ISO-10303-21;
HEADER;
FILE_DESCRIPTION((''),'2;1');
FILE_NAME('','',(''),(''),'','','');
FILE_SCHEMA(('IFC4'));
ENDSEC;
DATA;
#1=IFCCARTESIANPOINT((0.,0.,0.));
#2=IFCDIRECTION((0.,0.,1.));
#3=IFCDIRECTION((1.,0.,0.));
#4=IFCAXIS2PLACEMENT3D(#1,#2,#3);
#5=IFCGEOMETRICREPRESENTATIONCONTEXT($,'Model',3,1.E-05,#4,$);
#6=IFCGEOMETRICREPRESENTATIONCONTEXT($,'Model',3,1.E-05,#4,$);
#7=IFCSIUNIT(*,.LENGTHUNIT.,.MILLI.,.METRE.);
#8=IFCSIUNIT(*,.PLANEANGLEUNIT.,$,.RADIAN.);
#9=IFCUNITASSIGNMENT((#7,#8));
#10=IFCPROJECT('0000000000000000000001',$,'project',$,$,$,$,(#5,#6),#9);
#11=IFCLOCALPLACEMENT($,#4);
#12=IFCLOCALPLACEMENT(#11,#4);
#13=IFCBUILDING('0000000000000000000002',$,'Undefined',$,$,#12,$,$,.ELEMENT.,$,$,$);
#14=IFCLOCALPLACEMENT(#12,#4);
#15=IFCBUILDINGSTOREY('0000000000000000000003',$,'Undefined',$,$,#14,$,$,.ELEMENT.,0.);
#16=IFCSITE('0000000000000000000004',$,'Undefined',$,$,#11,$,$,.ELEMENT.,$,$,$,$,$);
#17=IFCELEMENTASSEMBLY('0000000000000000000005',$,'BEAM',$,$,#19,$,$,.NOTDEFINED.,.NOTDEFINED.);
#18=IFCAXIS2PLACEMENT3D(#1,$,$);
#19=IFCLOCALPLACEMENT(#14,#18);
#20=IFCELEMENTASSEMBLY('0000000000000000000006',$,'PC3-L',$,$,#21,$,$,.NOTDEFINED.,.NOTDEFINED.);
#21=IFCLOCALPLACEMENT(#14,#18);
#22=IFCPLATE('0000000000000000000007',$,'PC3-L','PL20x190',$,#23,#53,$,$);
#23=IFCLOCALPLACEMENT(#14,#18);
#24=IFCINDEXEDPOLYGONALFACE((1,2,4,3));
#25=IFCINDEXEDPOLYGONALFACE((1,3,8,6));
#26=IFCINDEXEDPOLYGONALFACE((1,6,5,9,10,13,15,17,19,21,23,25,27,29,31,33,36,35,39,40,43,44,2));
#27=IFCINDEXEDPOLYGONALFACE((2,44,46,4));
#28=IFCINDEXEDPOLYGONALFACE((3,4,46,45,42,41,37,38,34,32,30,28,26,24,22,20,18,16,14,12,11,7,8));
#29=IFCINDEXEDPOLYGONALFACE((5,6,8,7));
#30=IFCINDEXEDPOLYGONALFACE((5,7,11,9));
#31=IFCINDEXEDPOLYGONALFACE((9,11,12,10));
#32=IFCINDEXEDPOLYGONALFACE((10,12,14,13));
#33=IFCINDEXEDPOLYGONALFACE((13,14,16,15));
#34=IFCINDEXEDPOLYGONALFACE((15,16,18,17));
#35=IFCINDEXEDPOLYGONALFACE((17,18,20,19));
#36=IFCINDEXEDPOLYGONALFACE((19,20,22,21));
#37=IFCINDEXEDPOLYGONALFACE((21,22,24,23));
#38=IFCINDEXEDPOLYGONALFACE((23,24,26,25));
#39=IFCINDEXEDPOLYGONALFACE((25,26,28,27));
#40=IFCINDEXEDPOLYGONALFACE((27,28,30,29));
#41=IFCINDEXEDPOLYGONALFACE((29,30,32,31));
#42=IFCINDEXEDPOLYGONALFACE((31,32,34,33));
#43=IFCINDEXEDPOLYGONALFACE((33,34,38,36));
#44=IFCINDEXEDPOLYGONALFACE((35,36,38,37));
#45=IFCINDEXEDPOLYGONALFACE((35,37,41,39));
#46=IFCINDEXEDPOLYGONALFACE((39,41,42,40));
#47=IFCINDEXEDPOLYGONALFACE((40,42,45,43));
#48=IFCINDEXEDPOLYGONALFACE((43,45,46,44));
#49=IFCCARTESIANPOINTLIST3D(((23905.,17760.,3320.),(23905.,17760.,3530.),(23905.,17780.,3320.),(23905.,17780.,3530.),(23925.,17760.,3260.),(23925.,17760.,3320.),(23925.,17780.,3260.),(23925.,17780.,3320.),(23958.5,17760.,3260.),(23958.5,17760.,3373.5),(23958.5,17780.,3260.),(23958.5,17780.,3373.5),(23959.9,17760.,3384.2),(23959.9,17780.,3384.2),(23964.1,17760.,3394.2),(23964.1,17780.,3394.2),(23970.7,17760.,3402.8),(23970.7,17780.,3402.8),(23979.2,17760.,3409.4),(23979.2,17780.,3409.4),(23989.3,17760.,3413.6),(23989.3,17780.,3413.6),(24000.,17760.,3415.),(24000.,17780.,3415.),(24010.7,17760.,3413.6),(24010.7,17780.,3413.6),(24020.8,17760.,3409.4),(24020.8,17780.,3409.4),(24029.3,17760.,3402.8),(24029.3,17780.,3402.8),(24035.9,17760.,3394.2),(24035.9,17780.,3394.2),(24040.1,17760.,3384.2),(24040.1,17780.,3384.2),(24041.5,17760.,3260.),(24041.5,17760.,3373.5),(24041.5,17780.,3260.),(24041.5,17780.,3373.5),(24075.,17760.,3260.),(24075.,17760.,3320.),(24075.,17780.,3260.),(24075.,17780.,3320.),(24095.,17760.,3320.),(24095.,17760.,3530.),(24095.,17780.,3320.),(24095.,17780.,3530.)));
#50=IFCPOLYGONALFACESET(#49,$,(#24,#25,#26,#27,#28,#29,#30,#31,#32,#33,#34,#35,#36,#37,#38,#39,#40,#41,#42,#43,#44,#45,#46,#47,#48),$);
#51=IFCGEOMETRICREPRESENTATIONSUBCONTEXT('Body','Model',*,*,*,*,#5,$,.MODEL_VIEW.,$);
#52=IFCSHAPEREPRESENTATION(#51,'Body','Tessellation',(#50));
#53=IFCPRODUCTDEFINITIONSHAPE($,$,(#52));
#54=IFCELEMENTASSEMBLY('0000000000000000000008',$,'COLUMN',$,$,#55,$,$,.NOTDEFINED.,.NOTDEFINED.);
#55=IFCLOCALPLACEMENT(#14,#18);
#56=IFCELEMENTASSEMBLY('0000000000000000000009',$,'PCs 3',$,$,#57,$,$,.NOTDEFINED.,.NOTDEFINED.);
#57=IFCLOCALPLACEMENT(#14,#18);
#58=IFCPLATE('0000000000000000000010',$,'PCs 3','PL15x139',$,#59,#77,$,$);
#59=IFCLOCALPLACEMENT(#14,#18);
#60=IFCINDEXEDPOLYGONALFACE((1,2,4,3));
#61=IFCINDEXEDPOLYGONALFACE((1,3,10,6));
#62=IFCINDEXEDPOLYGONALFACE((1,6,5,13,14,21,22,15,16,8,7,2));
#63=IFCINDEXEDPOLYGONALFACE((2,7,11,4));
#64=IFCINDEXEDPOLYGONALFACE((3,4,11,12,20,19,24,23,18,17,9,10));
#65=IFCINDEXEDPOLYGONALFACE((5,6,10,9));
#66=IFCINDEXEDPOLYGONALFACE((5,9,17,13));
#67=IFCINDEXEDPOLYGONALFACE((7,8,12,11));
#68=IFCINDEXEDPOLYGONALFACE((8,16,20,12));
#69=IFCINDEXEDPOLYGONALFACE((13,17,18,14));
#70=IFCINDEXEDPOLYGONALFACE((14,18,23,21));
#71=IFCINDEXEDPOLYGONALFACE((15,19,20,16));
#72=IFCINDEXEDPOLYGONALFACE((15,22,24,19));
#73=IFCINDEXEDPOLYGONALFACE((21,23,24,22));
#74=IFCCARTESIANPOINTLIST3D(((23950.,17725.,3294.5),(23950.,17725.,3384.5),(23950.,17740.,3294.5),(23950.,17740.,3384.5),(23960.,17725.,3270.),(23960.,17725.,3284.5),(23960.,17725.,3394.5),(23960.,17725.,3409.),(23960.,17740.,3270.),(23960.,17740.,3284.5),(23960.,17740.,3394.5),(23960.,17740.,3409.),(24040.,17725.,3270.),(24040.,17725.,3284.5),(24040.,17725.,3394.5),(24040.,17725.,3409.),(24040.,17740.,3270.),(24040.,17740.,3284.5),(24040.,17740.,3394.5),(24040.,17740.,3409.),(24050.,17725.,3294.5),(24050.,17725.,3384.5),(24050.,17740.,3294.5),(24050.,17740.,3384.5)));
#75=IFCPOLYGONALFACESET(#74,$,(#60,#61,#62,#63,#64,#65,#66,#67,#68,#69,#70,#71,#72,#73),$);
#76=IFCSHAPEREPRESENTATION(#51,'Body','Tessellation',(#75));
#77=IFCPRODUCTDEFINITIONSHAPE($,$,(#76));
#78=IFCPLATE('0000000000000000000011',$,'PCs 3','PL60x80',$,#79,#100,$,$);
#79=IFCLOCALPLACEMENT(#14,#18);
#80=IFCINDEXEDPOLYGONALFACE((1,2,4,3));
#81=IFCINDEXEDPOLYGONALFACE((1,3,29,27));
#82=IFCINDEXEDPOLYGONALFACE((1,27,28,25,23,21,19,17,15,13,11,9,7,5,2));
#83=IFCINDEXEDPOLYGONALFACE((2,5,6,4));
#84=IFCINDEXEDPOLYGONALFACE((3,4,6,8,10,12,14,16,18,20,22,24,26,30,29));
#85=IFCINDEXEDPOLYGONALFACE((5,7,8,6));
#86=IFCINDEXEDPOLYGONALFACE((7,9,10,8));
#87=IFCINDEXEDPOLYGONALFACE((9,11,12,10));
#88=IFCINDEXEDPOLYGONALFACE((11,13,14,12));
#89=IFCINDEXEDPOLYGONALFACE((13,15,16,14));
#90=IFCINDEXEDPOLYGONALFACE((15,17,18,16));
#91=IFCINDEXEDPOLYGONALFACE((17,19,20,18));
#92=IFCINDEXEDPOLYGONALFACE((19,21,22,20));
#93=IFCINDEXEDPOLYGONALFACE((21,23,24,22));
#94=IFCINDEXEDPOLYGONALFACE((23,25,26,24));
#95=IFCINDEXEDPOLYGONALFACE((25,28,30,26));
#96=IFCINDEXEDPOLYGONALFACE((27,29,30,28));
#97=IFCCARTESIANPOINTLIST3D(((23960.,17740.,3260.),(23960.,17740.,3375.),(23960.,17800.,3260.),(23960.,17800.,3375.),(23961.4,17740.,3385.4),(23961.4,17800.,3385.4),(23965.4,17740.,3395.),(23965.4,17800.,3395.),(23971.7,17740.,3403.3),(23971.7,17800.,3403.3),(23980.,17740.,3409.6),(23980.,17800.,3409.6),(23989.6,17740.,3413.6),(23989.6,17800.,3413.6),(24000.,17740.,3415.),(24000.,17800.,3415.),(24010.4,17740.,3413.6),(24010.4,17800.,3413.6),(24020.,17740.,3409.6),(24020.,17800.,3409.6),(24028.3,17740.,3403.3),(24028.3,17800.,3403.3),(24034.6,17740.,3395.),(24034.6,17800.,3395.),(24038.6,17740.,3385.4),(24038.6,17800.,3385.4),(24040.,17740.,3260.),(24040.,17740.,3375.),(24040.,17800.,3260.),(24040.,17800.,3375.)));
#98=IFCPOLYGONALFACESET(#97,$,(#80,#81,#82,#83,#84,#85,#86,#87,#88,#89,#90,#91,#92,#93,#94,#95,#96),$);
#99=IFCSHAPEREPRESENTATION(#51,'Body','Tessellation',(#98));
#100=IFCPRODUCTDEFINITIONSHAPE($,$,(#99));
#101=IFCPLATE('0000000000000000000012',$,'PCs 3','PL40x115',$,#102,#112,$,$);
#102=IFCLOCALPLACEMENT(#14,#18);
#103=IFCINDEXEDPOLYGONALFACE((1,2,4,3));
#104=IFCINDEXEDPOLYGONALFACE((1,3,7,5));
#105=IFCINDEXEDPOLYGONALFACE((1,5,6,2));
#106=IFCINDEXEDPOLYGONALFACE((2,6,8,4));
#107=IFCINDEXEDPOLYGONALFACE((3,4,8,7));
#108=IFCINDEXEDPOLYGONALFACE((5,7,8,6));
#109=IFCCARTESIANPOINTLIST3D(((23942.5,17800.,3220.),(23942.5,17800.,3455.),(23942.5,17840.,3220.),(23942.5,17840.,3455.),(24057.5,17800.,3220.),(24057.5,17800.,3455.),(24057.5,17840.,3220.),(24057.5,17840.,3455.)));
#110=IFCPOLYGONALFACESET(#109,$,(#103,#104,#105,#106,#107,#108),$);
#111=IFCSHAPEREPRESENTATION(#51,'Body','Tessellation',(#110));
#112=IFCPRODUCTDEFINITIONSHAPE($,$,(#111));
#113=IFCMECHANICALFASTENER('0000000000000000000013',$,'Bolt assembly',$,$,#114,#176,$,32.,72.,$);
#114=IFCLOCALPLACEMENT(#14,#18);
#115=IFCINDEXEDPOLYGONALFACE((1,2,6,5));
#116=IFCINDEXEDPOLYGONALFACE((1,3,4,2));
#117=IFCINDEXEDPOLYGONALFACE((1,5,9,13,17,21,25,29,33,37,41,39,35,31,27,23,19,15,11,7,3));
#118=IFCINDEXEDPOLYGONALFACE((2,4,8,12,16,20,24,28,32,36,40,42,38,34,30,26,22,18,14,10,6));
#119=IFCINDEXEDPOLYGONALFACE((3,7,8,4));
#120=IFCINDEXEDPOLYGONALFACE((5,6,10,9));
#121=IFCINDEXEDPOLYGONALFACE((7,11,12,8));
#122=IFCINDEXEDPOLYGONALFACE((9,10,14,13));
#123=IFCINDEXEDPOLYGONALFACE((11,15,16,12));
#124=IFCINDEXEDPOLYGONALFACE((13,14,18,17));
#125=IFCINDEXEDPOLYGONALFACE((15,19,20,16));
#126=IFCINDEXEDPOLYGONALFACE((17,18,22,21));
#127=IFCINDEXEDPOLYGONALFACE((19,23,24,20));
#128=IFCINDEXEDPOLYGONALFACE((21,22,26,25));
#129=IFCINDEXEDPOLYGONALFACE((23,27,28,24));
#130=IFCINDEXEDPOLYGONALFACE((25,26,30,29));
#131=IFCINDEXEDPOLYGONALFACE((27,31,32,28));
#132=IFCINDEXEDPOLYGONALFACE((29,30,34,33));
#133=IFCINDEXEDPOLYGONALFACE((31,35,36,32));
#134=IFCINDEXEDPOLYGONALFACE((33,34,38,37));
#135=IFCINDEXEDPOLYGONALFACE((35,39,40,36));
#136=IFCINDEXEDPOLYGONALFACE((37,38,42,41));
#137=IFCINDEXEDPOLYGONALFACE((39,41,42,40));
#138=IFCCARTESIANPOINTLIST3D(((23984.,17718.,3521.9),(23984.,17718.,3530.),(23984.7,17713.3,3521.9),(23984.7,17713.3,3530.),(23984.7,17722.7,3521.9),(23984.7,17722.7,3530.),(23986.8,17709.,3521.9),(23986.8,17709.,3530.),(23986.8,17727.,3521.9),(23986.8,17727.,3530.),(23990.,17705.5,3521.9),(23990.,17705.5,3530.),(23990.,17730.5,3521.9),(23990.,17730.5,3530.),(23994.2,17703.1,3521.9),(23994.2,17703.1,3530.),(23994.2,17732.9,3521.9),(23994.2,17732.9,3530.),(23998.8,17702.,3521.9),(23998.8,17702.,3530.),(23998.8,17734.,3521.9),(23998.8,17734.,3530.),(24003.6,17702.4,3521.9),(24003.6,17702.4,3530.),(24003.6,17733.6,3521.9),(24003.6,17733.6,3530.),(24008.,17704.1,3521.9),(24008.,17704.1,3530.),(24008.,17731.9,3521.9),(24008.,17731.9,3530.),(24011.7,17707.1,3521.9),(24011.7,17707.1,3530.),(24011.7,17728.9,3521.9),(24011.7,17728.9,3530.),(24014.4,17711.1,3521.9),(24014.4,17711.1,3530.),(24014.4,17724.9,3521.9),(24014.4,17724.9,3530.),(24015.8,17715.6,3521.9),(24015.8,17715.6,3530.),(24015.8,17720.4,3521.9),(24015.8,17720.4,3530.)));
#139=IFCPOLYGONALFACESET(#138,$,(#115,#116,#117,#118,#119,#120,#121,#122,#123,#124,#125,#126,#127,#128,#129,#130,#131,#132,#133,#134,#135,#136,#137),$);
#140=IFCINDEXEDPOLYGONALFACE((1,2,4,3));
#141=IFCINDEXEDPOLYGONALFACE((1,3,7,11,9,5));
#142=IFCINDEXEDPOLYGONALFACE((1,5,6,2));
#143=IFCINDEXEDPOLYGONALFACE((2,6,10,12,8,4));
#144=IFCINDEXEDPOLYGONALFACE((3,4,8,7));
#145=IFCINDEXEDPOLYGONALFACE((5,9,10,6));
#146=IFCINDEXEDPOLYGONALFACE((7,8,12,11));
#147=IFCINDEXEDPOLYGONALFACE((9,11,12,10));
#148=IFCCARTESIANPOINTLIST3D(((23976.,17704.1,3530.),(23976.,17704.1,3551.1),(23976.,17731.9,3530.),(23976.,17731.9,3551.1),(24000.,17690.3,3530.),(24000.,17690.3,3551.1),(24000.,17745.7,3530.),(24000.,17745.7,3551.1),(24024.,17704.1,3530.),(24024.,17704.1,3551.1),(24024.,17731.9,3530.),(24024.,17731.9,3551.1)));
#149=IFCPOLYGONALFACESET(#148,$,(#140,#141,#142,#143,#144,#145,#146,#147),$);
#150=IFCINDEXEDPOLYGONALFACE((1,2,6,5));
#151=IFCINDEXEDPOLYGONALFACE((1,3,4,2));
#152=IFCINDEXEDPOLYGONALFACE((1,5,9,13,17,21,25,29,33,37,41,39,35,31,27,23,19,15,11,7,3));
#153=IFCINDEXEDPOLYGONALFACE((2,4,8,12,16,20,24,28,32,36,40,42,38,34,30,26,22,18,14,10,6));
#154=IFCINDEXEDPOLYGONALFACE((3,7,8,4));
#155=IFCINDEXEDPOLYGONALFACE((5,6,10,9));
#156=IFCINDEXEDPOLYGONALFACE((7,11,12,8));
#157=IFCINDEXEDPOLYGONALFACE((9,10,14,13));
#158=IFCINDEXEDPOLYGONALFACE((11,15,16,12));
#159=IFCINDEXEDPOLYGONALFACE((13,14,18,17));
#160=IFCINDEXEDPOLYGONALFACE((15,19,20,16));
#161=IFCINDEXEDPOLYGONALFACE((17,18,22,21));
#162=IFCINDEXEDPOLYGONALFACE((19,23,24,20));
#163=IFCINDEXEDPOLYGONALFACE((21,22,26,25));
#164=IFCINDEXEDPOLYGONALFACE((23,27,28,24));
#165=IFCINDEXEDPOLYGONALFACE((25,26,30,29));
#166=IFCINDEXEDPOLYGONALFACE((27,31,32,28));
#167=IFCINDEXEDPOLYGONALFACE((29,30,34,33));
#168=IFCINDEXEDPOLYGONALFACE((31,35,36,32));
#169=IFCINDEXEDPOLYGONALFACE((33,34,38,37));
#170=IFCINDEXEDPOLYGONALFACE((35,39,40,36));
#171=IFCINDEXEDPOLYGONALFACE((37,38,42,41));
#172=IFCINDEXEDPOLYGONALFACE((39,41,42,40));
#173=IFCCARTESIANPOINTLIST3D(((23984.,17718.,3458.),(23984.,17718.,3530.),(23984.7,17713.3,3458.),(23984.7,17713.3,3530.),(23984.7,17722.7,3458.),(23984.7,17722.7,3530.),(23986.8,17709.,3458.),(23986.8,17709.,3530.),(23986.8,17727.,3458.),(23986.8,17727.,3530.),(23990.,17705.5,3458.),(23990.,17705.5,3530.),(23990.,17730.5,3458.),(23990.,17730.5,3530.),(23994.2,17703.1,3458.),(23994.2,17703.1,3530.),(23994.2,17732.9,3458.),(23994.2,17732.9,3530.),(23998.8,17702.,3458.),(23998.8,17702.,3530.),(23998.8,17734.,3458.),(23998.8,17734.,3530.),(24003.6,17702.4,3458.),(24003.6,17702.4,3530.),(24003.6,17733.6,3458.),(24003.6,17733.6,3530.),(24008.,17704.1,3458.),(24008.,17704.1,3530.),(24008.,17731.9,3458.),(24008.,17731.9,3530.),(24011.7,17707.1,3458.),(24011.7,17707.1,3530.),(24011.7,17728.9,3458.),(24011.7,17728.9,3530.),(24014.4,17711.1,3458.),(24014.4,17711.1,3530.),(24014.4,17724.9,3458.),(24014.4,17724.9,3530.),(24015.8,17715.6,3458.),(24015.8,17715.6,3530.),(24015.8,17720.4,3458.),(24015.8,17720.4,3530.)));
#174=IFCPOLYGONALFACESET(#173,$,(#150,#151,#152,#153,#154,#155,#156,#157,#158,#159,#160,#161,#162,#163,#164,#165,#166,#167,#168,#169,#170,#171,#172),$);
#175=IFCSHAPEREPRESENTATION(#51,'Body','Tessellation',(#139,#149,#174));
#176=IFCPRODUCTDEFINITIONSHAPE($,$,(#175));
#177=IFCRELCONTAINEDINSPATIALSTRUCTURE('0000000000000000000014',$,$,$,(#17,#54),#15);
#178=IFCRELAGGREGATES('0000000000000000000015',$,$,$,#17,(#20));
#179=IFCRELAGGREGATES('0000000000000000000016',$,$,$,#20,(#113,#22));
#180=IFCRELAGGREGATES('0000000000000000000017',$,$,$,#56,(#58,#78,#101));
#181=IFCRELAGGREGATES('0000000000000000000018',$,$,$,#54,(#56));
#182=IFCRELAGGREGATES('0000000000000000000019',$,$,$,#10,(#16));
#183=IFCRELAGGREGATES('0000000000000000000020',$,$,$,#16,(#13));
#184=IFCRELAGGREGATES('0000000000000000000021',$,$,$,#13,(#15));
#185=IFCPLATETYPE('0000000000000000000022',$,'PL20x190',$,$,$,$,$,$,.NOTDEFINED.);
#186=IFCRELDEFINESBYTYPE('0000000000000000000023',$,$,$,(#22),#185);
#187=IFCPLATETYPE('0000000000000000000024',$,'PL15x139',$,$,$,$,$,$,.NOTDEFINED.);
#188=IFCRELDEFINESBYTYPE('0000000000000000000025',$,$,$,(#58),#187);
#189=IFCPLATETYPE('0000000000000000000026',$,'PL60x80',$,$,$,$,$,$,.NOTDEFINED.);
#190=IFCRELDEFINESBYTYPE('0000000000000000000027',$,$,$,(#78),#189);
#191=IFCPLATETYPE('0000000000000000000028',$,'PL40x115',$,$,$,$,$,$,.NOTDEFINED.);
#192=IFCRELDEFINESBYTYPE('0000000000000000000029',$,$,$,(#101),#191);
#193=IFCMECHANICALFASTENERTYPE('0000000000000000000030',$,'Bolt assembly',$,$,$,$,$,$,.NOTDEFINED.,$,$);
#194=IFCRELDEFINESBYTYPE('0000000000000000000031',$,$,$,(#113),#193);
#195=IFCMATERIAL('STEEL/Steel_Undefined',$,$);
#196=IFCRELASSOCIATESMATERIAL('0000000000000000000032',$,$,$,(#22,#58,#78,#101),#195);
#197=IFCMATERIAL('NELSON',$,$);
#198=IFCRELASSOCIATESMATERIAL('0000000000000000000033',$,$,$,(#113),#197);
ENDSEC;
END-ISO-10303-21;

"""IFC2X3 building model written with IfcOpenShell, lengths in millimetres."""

from ifc_helpers import new_model, si_unit, frame, frame_2d, origin_with_axes, origin_2d_with_axis, place, context, subcontext, project, spatial, polyline, circle_curve, parameter, trimmed, segment, composite_curve, circle, outline, extrude, source, transform, mapped, material, type_object, element, aggregate, save


model = new_model("IFC2X3")

# Units and contexts
model_context_1 = context("Model", 3, precision=1e-05, world=origin_with_axes())
model_context_2 = context("Model", 3, precision=1e-05, world=origin_with_axes())
body_context = subcontext(model_context_1, "Body", "Model", "MODEL_VIEW")
ifc_project = project(units=[si_unit("LENGTHUNIT", "METRE", prefix="MILLI"), si_unit("PLANEANGLEUNIT", "RADIAN")], contexts=[model_context_1, model_context_2])

# Site, building, storey
site_placement = place(None, origin_with_axes())
site = spatial("IfcSite", under=ifc_project, at=site_placement, Name="Undefined", CompositionType="ELEMENT")
building_placement = place(site_placement, origin_with_axes())
building = spatial("IfcBuilding", under=site, at=building_placement, Name="Undefined", CompositionType="ELEMENT")
storey_placement = place(building_placement, origin_with_axes())
storey = spatial("IfcBuildingStorey", under=building, at=storey_placement, Name="Undefined", CompositionType="ELEMENT", Elevation=0.0)

# Element assemblies
assembly_1_placement = place(storey_placement, origin_with_axes())
assembly_1 = element("IfcElementAssembly", 1, at=assembly_1_placement, inside=storey, Name="BEAM", AssemblyPlace="NOTDEFINED", PredefinedType="NOTDEFINED")
assembly_2_placement = place(assembly_1_placement, origin_with_axes())
assembly_2 = element("IfcElementAssembly", 2, at=assembly_2_placement, Name="PC3-L", AssemblyPlace="NOTDEFINED", PredefinedType="NOTDEFINED")
aggregate(assembly_1, [assembly_2])
ifc_material_1 = material(Name="STEEL/Steel_Undefined")

# Plate
plate_type_1 = type_object("IfcPlateType", Name="PL20x190", PredefinedType="NOTDEFINED")
plate_1_placement = place(assembly_2_placement, frame((24095.0, 17770.0, 3260.0), z_axis=(0.0, 1.0, 0.0), x_axis=(-1.0, 0.0, 0.0)))
plate_1 = element("IfcPlate", 3, at=plate_1_placement, type_object=plate_type_1, material=ifc_material_1, Name="PC3-L", Description="PL20x190", context=body_context, shape_type="SweptSolid", body=[
    extrude(outline(composite_curve([segment(polyline([(0.0, 60.0), (20.0, 60.0), (20.0, 0.0), (53.5, 0.0), (53.5, 113.5)]), True, "CONTINUOUS"), segment(trimmed(circle_curve(frame_2d((95.0, 113.5), x_axis=(-1.0, 0.0)), 41.5), [parameter(0.0)], [parameter(4.712389)], False, "PARAMETER"), True, "CONTINUOUS"), segment(polyline([(95.0, 155.0), (95.0, 155.0)]), True, "CONTINUOUS"), segment(trimmed(circle_curve(frame_2d((95.0, 113.5), x_axis=(0.0, 1.0)), 41.5), [parameter(0.0)], [parameter(4.712389)], False, "PARAMETER"), True, "CONTINUOUS"), segment(polyline([(136.5, 113.5), (136.5, 0.0), (170.0, 0.0), (170.0, 60.0), (190.0, 60.0), (190.0, 270.0), (0.0, 270.0), (0.0, 60.0)]), True, "CONTINUOUS")], self_intersect=True)), frame((0.0, 0.0, -10.0), z_axis=(0.0, 0.0, 1.0), x_axis=(1.0, 0.0, 0.0)), (0.0, 0.0, 1.0), 20.0),
])

# Element assemblies, plates
assembly_3_placement = place(storey_placement, origin_with_axes())
assembly_3 = element("IfcElementAssembly", 4, at=assembly_3_placement, inside=storey, Name="COLUMN", AssemblyPlace="NOTDEFINED", PredefinedType="NOTDEFINED")
assembly_4_placement = place(assembly_3_placement, origin_with_axes())
assembly_4 = element("IfcElementAssembly", 5, at=assembly_4_placement, Name="PCs 3", AssemblyPlace="NOTDEFINED", PredefinedType="NOTDEFINED")
plate_type_2 = type_object("IfcPlateType", Name="PL15x139", PredefinedType="NOTDEFINED")
plate_2_placement = place(assembly_4_placement, frame((23960.0, 17732.5, 3409.0), z_axis=(0.0, -1.0, 0.0), x_axis=(0.0, 0.0, -1.0)))
plate_2 = element("IfcPlate", 6, at=plate_2_placement, type_object=plate_type_2, material=ifc_material_1, Name="PCs 3", Description="PL15x139", context=body_context, shape_type="SweptSolid", body=[
    extrude(outline(polyline([(0.0, 0.0), (14.5, 0.0), (24.5, -10.0), (114.5, -10.0), (124.5, 0.0), (139.0, 0.0), (139.0, 80.0), (124.5, 80.0), (114.5, 90.0), (24.5, 90.0), (14.5, 80.0), (0.0, 80.0), (0.0, 0.0)])), frame((0.0, 0.0, -7.5), z_axis=(0.0, 0.0, 1.0), x_axis=(1.0, 0.0, 0.0)), (0.0, 0.0, 1.0), 15.0),
])
plate_type_3 = type_object("IfcPlateType", Name="PL60x80", PredefinedType="NOTDEFINED")
plate_3_placement = place(assembly_4_placement, frame((23960.0, 17770.0, 3415.0), z_axis=(0.0, -1.0, 0.0), x_axis=(0.0, 0.0, -1.0)))
plate_3 = element("IfcPlate", 7, at=plate_3_placement, type_object=plate_type_3, material=ifc_material_1, Name="PCs 3", Description="PL60x80", context=body_context, shape_type="SweptSolid", body=[
    extrude(outline(composite_curve([segment(trimmed(circle_curve(frame_2d((40.0, 40.0), x_axis=(-1.0, 0.0)), 40.0), [parameter(0.0)], [parameter(1.570796)], True, "PARAMETER"), True, "CONTINUOUS"), segment(polyline([(40.0, 0.0), (155.0, 0.0), (155.0, 80.0), (40.0, 80.0)]), True, "CONTINUOUS"), segment(trimmed(circle_curve(frame_2d((40.0, 40.0), x_axis=(0.0, 1.0)), 40.0), [parameter(0.0)], [parameter(1.570796)], True, "PARAMETER"), True, "CONTINUOUS"), segment(polyline([(0.0, 40.0), (0.0, 40.0)]), True, "CONTINUOUS")], self_intersect=True)), frame((0.0, 0.0, -30.0), z_axis=(0.0, 0.0, 1.0), x_axis=(1.0, 0.0, 0.0)), (0.0, 0.0, 1.0), 60.0),
])
plate_type_4 = type_object("IfcPlateType", Name="PL40x115", PredefinedType="NOTDEFINED")
plate_4_placement = place(assembly_4_placement, frame((23942.5, 17820.0, 3455.0), z_axis=(0.0, -1.0, 0.0), x_axis=(0.0, 0.0, -1.0)))
plate_4 = element("IfcPlate", 8, at=plate_4_placement, type_object=plate_type_4, material=ifc_material_1, Name="PCs 3", Description="PL40x115", context=body_context, shape_type="SweptSolid", body=[
    extrude(outline(polyline([(0.0, 0.0), (235.0, 0.0), (235.0, 115.0), (0.0, 115.0), (0.0, 0.0)])), frame((0.0, 0.0, -20.0), z_axis=(0.0, 0.0, 1.0), x_axis=(1.0, 0.0, 0.0)), (0.0, 0.0, 1.0), 40.0),
])

# Mechanical fastener
ifc_material_2 = material(Name="NELSON")
mechanical_fastener_type = type_object("IfcMechanicalFastenerType", Name="Bolt assembly")
shared_shape_1 = source(origin_with_axes(), body_context, "Body", "SweptSolid", [
    extrude(circle(Radius=16.0, at=origin_2d_with_axis()), frame((0.0, -8.0, 0.0), z_axis=(0.0, 1.0, 0.0), x_axis=(1.0, 0.0, 0.0)), (0.0, 0.0, 1.0), 8.1),
    extrude(outline(polyline([(24.0, -13.9), (24.0, 13.9), (0.0, 27.7), (-24.0, 13.9), (-24.0, -13.9), (0.0, -27.7), (24.0, -13.9)])), frame((0.0, -29.1, 0.0), z_axis=(0.0, 1.0, 0.0), x_axis=(1.0, 0.0, 0.0)), (0.0, 0.0, 1.0), 21.1),
    extrude(circle(Radius=16.0, at=origin_2d_with_axis()), frame((0.0, -8.0, 0.0), z_axis=(0.0, 1.0, 0.0), x_axis=(1.0, 0.0, 0.0)), (0.0, 0.0, 1.0), 72.0),
])
mechanical_fastener_placement = place(assembly_2_placement, frame((24000.0, 17718.0, 3522.0), z_axis=(0.0, -1.0, 0.0), x_axis=(-1.0, 0.0, 0.0)))
mechanical_fastener = element("IfcMechanicalFastener", 9, at=mechanical_fastener_placement, type_object=mechanical_fastener_type, material=ifc_material_2, Name="Bolt assembly", NominalDiameter=32.0, NominalLength=72.0, context=body_context, shape_type="MappedRepresentation", body=[
    mapped(shared_shape_1, transform((0.0, 0.0, 0.0))),
])

aggregate(assembly_2, [mechanical_fastener, plate_1])
aggregate(assembly_4, [plate_2, plate_3, plate_4])
aggregate(assembly_3, [assembly_4])

save(model, "model.ifc")
